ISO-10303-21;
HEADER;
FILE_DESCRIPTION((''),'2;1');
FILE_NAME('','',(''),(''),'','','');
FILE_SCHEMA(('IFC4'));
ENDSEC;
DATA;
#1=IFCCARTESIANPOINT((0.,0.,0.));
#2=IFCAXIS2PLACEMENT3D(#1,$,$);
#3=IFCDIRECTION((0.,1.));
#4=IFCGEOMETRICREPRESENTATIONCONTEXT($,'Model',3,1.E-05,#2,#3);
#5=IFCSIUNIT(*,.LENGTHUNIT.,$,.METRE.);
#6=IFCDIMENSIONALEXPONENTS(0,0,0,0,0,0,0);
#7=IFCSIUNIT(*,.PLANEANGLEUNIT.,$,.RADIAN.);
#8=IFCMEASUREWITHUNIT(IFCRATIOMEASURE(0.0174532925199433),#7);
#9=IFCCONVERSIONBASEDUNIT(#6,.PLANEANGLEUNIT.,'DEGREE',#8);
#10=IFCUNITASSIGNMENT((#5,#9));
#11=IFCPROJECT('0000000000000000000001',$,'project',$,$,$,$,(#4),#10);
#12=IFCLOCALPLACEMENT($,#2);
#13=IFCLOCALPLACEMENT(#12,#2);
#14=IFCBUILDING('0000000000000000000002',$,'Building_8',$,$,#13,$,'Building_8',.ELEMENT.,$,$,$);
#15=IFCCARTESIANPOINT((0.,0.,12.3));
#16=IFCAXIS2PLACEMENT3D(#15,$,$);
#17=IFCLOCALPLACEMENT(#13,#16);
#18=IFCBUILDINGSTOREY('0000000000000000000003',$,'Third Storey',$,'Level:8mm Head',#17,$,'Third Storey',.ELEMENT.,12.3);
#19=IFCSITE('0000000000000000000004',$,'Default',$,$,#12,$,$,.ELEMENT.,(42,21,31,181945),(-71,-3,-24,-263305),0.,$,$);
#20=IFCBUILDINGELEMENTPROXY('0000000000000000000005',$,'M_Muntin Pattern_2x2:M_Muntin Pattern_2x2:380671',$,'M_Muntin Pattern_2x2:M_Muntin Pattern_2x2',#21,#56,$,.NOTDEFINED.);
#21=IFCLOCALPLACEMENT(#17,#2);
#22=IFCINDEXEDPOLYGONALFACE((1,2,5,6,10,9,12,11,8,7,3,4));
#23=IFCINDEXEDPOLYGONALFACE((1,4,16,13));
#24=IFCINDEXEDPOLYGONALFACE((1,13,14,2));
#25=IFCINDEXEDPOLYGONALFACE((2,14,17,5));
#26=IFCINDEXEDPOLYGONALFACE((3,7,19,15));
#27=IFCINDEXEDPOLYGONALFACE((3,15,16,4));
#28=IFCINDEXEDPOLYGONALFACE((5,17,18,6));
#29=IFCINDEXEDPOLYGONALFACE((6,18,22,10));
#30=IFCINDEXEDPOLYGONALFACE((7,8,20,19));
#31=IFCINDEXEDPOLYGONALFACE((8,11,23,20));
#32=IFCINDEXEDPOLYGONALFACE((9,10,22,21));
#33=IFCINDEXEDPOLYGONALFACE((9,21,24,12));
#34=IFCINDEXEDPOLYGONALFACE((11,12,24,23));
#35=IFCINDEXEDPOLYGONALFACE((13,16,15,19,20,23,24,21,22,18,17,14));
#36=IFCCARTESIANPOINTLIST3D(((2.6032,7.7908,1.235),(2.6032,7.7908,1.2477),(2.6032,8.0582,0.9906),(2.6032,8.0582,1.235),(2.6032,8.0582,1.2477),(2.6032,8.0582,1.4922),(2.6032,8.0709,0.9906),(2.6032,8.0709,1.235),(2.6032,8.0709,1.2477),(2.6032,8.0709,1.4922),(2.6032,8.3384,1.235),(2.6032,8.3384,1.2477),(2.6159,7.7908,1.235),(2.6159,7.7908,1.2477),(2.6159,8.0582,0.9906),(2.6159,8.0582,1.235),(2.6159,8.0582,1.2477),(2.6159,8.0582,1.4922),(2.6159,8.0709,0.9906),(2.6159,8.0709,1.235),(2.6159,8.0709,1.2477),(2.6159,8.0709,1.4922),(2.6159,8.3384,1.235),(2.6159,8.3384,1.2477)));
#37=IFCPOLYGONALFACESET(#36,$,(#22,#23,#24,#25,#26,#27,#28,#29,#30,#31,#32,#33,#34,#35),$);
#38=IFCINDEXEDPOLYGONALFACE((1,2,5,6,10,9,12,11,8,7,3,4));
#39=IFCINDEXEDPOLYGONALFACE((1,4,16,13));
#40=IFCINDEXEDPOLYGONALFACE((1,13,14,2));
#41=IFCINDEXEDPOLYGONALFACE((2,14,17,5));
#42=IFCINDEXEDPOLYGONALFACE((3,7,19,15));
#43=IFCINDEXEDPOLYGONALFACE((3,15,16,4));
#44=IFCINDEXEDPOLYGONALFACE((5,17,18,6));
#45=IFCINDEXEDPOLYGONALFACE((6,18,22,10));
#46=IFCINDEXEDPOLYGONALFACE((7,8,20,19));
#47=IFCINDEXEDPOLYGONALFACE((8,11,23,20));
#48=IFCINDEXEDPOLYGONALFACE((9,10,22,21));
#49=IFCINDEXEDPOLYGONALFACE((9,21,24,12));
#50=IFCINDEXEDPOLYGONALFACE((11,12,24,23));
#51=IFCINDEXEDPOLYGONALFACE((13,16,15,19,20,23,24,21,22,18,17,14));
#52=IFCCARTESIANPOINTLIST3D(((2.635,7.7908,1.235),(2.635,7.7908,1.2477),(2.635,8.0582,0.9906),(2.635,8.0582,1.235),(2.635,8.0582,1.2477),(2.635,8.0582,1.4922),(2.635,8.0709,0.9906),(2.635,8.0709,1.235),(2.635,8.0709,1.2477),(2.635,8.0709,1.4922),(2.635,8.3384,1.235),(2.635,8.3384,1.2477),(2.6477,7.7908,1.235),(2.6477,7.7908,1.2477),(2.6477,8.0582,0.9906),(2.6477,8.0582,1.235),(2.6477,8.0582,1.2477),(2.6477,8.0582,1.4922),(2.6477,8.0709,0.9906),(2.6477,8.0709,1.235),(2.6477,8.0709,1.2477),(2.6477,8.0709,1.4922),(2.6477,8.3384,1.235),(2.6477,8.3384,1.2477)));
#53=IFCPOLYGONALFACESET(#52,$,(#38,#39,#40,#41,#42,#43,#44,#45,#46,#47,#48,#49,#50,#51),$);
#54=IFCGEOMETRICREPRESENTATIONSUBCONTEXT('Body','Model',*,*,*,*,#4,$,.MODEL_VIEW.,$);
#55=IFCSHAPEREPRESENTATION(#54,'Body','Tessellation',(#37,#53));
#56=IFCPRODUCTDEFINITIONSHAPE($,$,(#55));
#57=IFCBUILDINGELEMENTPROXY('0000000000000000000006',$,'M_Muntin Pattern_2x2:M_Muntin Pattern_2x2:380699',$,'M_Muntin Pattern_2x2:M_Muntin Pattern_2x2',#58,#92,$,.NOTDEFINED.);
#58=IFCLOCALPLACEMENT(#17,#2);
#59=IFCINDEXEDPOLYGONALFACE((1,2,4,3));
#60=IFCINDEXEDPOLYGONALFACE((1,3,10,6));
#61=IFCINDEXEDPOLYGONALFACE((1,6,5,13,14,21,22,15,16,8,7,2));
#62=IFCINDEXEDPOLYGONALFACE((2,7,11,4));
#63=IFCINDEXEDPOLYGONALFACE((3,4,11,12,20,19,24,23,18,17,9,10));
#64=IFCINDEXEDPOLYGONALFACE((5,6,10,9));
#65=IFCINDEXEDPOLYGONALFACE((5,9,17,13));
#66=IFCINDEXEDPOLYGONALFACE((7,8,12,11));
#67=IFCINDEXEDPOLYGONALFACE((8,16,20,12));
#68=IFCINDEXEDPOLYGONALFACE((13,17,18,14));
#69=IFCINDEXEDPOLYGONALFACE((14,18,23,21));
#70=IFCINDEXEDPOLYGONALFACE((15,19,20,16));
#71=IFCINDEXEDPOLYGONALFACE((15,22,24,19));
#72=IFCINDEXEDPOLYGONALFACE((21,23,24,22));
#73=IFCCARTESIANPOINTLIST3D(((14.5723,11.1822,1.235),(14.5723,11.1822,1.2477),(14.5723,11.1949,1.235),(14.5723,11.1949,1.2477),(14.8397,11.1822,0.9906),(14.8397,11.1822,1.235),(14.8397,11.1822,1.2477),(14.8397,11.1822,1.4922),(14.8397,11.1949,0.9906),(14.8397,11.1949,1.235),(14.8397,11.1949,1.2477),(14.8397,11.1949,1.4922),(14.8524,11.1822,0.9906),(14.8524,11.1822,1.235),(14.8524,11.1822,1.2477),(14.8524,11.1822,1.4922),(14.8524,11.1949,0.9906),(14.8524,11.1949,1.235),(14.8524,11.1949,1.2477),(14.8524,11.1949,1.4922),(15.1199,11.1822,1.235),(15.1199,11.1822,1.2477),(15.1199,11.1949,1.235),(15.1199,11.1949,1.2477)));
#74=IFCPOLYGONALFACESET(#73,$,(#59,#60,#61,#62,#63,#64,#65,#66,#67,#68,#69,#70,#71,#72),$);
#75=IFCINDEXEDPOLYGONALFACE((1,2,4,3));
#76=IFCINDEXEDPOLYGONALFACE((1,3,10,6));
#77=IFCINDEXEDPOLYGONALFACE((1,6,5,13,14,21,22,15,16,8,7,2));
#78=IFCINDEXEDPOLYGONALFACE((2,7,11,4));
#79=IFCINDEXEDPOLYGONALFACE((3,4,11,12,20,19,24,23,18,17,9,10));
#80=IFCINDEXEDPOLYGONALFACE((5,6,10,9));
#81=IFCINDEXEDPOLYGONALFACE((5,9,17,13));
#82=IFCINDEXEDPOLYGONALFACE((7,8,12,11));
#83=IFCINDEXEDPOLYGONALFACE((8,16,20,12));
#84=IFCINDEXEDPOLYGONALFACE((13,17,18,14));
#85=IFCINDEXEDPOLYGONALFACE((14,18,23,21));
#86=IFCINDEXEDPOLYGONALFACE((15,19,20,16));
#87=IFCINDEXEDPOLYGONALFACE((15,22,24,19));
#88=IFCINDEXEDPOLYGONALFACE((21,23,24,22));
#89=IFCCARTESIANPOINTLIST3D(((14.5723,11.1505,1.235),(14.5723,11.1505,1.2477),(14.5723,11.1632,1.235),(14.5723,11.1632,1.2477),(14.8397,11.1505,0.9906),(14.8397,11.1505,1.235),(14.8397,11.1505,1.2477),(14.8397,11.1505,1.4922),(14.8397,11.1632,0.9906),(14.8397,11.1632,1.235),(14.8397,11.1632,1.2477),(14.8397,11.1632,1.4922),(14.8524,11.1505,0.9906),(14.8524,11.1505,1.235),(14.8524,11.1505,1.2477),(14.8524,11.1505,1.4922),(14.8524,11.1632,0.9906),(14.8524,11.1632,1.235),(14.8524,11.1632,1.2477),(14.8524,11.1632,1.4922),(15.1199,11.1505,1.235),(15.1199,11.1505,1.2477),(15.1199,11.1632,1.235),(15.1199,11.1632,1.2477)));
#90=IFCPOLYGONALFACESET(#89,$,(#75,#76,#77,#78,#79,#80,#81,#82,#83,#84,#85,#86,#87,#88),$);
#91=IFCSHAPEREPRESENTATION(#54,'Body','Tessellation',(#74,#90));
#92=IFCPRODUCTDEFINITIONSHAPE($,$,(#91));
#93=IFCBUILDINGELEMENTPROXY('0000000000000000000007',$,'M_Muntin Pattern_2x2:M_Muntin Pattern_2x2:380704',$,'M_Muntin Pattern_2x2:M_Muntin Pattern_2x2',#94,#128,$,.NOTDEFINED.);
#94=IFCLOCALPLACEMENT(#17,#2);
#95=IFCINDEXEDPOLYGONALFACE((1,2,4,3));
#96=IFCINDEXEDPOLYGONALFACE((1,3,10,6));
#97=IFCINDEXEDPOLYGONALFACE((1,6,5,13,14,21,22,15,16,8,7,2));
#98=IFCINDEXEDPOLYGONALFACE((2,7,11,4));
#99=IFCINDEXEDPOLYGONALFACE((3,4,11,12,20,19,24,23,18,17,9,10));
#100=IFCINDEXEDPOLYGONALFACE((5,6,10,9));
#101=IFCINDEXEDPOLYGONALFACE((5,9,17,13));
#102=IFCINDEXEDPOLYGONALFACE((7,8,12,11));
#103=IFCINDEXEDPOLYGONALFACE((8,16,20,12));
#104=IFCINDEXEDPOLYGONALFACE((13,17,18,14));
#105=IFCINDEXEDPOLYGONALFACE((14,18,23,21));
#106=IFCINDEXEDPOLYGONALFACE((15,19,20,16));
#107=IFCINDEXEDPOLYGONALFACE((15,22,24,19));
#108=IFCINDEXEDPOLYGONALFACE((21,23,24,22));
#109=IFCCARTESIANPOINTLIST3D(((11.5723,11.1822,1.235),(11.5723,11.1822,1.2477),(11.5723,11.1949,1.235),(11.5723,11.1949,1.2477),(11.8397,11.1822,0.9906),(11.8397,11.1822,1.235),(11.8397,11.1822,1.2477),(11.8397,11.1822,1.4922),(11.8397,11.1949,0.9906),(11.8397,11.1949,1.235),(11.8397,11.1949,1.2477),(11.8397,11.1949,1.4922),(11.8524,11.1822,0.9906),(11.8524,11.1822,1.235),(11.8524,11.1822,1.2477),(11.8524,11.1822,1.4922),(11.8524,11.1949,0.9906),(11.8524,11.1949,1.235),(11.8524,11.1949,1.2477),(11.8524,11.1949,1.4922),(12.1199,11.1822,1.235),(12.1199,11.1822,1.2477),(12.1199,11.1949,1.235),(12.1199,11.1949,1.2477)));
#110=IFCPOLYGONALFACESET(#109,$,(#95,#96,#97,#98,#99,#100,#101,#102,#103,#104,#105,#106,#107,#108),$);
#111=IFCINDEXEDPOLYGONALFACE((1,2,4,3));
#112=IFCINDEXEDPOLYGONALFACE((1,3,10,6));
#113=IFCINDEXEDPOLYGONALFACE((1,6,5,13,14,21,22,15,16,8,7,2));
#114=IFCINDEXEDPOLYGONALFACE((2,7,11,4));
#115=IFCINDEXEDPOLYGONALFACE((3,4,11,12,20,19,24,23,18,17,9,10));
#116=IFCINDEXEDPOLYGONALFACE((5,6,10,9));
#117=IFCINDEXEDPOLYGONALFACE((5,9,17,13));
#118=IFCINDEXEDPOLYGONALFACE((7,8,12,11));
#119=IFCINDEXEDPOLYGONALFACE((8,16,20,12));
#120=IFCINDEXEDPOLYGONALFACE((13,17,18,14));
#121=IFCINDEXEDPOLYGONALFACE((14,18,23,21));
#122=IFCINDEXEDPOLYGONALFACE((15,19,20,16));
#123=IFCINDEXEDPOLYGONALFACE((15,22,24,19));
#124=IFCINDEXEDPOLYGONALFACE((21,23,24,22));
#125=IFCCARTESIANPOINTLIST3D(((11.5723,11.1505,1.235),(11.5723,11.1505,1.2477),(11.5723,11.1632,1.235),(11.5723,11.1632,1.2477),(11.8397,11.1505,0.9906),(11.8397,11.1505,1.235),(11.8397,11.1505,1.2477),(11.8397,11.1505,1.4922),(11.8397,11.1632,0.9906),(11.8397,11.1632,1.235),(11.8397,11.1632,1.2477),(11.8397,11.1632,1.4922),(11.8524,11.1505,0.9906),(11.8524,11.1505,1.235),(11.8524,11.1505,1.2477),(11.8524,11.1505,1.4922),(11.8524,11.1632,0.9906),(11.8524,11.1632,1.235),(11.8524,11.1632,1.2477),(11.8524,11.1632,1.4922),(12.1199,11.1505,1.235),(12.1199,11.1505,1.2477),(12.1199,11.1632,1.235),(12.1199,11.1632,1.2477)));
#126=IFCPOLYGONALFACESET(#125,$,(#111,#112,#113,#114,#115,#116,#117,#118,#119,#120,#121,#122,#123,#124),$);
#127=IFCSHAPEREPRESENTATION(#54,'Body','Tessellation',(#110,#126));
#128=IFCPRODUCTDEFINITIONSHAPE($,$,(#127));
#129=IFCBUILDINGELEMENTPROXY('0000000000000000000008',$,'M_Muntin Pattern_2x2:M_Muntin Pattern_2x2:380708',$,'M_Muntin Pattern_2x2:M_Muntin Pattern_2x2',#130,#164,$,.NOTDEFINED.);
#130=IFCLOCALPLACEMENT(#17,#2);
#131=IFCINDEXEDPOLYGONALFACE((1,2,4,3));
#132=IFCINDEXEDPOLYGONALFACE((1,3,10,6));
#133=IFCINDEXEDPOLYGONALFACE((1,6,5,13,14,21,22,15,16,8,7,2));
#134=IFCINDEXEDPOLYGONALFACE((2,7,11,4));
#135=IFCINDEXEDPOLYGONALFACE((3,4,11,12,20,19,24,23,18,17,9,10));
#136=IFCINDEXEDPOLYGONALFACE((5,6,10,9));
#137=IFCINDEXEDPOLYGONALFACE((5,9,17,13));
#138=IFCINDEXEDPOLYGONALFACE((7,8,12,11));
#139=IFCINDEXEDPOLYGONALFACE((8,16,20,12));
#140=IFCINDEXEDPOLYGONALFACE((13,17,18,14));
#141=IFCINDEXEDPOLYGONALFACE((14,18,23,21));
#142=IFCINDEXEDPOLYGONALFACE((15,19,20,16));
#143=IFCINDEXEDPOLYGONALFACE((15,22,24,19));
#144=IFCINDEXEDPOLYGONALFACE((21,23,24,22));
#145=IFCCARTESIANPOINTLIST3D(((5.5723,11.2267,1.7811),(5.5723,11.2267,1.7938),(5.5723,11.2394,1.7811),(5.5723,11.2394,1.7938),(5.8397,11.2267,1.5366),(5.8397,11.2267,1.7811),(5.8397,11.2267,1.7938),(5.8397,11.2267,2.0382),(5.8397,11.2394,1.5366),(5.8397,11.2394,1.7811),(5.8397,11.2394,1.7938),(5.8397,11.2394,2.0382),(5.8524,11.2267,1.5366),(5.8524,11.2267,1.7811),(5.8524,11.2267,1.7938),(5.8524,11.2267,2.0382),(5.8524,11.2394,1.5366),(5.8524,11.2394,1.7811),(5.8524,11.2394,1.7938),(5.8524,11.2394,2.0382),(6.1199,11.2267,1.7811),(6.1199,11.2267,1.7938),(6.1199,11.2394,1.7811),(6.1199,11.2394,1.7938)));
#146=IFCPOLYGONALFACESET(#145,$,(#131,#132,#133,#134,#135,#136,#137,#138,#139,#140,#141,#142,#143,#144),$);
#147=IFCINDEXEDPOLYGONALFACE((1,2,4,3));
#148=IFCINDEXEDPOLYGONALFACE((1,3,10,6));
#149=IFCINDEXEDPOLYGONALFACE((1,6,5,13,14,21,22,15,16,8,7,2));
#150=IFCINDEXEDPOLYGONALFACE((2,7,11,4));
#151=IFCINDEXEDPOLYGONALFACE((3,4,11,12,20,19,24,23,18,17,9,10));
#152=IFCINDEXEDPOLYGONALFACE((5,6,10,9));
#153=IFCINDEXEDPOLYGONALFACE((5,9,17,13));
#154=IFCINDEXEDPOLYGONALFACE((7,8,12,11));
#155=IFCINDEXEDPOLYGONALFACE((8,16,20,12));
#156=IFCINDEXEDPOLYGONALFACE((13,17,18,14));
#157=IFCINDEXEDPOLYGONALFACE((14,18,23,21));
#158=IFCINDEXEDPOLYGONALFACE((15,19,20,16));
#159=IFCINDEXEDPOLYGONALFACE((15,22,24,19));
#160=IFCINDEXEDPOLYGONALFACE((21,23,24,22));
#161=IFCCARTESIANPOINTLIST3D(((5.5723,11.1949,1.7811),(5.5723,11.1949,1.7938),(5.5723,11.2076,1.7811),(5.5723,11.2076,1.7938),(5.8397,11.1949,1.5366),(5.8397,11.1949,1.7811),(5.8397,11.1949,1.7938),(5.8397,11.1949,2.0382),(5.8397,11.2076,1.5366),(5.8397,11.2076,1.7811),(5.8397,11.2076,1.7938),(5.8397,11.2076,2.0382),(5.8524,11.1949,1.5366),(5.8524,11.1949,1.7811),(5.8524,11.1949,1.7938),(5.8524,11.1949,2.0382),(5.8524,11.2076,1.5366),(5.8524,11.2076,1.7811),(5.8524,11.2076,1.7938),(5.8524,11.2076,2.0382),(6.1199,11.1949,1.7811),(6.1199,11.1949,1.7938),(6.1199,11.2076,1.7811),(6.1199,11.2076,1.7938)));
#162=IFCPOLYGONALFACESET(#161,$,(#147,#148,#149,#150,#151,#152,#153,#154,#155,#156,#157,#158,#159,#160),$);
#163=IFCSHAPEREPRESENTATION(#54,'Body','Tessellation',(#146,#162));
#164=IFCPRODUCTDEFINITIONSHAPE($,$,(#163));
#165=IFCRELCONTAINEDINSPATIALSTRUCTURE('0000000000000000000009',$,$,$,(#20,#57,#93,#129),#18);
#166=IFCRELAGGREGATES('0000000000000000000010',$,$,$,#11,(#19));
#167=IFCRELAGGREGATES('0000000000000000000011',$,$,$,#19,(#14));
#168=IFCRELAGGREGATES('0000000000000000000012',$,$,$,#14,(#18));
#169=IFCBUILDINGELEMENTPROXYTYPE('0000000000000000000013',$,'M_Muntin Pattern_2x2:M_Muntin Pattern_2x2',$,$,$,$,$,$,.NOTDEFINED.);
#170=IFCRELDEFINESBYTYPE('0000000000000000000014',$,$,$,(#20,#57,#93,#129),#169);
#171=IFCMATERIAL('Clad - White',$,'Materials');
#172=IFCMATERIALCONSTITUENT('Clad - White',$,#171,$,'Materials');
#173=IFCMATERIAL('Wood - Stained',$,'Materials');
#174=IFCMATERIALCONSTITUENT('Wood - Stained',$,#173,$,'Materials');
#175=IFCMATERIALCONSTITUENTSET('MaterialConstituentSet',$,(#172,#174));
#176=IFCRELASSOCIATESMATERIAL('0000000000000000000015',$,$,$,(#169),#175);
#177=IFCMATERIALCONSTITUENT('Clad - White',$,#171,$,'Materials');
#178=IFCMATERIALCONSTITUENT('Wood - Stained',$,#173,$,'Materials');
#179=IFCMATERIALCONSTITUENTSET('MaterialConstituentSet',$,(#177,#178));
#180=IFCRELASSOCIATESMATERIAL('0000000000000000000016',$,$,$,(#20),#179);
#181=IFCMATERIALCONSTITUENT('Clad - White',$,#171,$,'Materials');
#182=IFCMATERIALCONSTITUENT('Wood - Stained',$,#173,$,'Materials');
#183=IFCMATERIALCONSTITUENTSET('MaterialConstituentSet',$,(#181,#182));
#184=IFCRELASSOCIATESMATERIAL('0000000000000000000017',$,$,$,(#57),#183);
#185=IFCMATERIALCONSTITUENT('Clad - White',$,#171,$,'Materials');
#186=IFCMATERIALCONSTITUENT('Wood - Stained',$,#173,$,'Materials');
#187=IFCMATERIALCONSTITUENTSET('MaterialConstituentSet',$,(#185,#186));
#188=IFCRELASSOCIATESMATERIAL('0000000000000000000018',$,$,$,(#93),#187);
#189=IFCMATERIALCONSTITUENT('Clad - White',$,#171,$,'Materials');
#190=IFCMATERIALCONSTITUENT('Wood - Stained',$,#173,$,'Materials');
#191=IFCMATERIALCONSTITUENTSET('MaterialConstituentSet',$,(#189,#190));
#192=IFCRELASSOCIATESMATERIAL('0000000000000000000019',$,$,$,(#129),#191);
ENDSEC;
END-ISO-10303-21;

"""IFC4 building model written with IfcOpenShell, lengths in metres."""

from ifc_helpers import new_model, entity, si_unit, converted_unit, direction, frame, origin, place, context, subcontext, project, spatial, indexed_curve, outline, extrude, source, transform, mapped, material, constituent, constituent_set, type_object, type_shapes, element, save


model = new_model("IFC4")

# Units and contexts
model_context = context("Model", 3, precision=1e-05, world=origin(), true_north=direction((0.0, 1.0)))
body_context = subcontext(model_context, "Body", "Model", "MODEL_VIEW")
ifc_project = project(units=[si_unit("LENGTHUNIT", "METRE"), converted_unit("PLANEANGLEUNIT", "DEGREE", entity("IfcRatioMeasure", 0.0174532925199433), si_unit("PLANEANGLEUNIT", "RADIAN"), dimensions=[0, 0, 0, 0, 0, 0, 0])], contexts=[model_context])

# Site, building, storey
site_placement = place(None, origin())
site = spatial("IfcSite", under=ifc_project, at=site_placement, Name="Default", CompositionType="ELEMENT", RefLatitude=(42, 21, 31, 181945), RefLongitude=(-71, -3, -24, -263305), RefElevation=0.0)
building_placement = place(site_placement, origin())
building = spatial("IfcBuilding", under=site, at=building_placement, Name="Building_8", LongName="Building_8", CompositionType="ELEMENT")
storey_placement = place(building_placement, frame((0.0, 0.0, 12.3)))
storey = spatial("IfcBuildingStorey", under=building, at=storey_placement, Name="Third Storey", ObjectType="Level:8mm Head", LongName="Third Storey", CompositionType="ELEMENT", Elevation=12.3)

# Building element proxies
ifc_material_1 = material(Name="Clad - White", Category="Materials")
ifc_material_2 = material(Name="Wood - Stained", Category="Materials")
ifc_constituent_1 = constituent(ifc_material_1, Name="Clad - White", Category="Materials")
ifc_constituent_2 = constituent(ifc_material_2, Name="Wood - Stained", Category="Materials")
ifc_constituent_set_1 = constituent_set(constituents=[ifc_constituent_1, ifc_constituent_2], Name="MaterialConstituentSet")
building_element_proxy_type_1 = type_object("IfcBuildingElementProxyType", Name="M_Muntin Pattern_2x2:M_Muntin Pattern_2x2", PredefinedType="NOTDEFINED", material=ifc_constituent_set_1)
shared_shape_1 = source(origin(), body_context, "Body", "SweptSolid", [
    extrude(outline(indexed_curve([(0.0064, -0.0064), (0.2508, -0.0064), (0.2508, 0.0063), (0.0064, 0.0063), (0.0064, 0.2738), (-0.0063, 0.2738), (-0.0063, 0.0063), (-0.2508, 0.0063), (-0.2508, -0.0064), (-0.0063, -0.0064), (-0.0063, -0.2738), (0.0064, -0.2738), (0.0064, -0.0064)], self_intersect=False)), frame((0.0, 0.0095, 0.2508), z_axis=(0.0, 1.0, 0.0), x_axis=(0.0, 0.0, 1.0)), (0.0, 0.0, 1.0), 0.0127),
    extrude(outline(indexed_curve([(0.0064, -0.0064), (0.2508, -0.0064), (0.2508, 0.0063), (0.0064, 0.0063), (0.0064, 0.2738), (-0.0063, 0.2738), (-0.0063, 0.0063), (-0.2508, 0.0063), (-0.2508, -0.0064), (-0.0063, -0.0064), (-0.0063, -0.2738), (0.0064, -0.2738), (0.0064, -0.0064)], self_intersect=False)), frame((0.0, -0.0222, 0.2508), z_axis=(0.0, 1.0, 0.0), x_axis=(0.0, 0.0, 1.0)), (0.0, 0.0, 1.0), 0.0127),
])
type_shapes(building_element_proxy_type_1, [shared_shape_1])
ifc_constituent_3 = constituent(ifc_material_1, Name="Clad - White", Category="Materials")
ifc_constituent_4 = constituent(ifc_material_2, Name="Wood - Stained", Category="Materials")
ifc_constituent_set_2 = constituent_set(constituents=[ifc_constituent_3, ifc_constituent_4], Name="MaterialConstituentSet")
proxy_1_placement = place(storey_placement, frame((2.6255, 8.0646, 0.9906), z_axis=(0.0, 0.0, 1.0), x_axis=(0.0, 1.0, 0.0)))
element("IfcBuildingElementProxy", 1, at=proxy_1_placement, inside=storey, type_object=building_element_proxy_type_1, material=ifc_constituent_set_2, Name="M_Muntin Pattern_2x2:M_Muntin Pattern_2x2:380671", ObjectType="M_Muntin Pattern_2x2:M_Muntin Pattern_2x2", PredefinedType="NOTDEFINED", context=body_context, shape_type="MappedRepresentation", body=[
    mapped(shared_shape_1, transform((0.0, 0.0, 0.0), scale=1.0)),
])
ifc_constituent_5 = constituent(ifc_material_1, Name="Clad - White", Category="Materials")
ifc_constituent_6 = constituent(ifc_material_2, Name="Wood - Stained", Category="Materials")
ifc_constituent_set_3 = constituent_set(constituents=[ifc_constituent_5, ifc_constituent_6], Name="MaterialConstituentSet")
proxy_2_placement = place(storey_placement, frame((14.8461, 11.1727, 0.9906)))
element("IfcBuildingElementProxy", 2, at=proxy_2_placement, inside=storey, type_object=building_element_proxy_type_1, material=ifc_constituent_set_3, Name="M_Muntin Pattern_2x2:M_Muntin Pattern_2x2:380699", ObjectType="M_Muntin Pattern_2x2:M_Muntin Pattern_2x2", PredefinedType="NOTDEFINED", context=body_context, shape_type="MappedRepresentation", body=[
    mapped(shared_shape_1, transform((0.0, 0.0, 0.0), scale=1.0)),
])
ifc_constituent_7 = constituent(ifc_material_1, Name="Clad - White", Category="Materials")
ifc_constituent_8 = constituent(ifc_material_2, Name="Wood - Stained", Category="Materials")
ifc_constituent_set_4 = constituent_set(constituents=[ifc_constituent_7, ifc_constituent_8], Name="MaterialConstituentSet")
proxy_3_placement = place(storey_placement, frame((11.8461, 11.1727, 0.9906)))
element("IfcBuildingElementProxy", 3, at=proxy_3_placement, inside=storey, type_object=building_element_proxy_type_1, material=ifc_constituent_set_4, Name="M_Muntin Pattern_2x2:M_Muntin Pattern_2x2:380704", ObjectType="M_Muntin Pattern_2x2:M_Muntin Pattern_2x2", PredefinedType="NOTDEFINED", context=body_context, shape_type="MappedRepresentation", body=[
    mapped(shared_shape_1, transform((0.0, 0.0, 0.0), scale=1.0)),
])
ifc_constituent_9 = constituent(ifc_material_1, Name="Clad - White", Category="Materials")
ifc_constituent_10 = constituent(ifc_material_2, Name="Wood - Stained", Category="Materials")
ifc_constituent_set_5 = constituent_set(constituents=[ifc_constituent_9, ifc_constituent_10], Name="MaterialConstituentSet")
proxy_4_placement = place(storey_placement, frame((5.8461, 11.2171, 1.5366)))
element("IfcBuildingElementProxy", 4, at=proxy_4_placement, inside=storey, type_object=building_element_proxy_type_1, material=ifc_constituent_set_5, Name="M_Muntin Pattern_2x2:M_Muntin Pattern_2x2:380708", ObjectType="M_Muntin Pattern_2x2:M_Muntin Pattern_2x2", PredefinedType="NOTDEFINED", context=body_context, shape_type="MappedRepresentation", body=[
    mapped(shared_shape_1, transform((0.0, 0.0, 0.0), scale=1.0)),
])

save(model, "model.ifc")
